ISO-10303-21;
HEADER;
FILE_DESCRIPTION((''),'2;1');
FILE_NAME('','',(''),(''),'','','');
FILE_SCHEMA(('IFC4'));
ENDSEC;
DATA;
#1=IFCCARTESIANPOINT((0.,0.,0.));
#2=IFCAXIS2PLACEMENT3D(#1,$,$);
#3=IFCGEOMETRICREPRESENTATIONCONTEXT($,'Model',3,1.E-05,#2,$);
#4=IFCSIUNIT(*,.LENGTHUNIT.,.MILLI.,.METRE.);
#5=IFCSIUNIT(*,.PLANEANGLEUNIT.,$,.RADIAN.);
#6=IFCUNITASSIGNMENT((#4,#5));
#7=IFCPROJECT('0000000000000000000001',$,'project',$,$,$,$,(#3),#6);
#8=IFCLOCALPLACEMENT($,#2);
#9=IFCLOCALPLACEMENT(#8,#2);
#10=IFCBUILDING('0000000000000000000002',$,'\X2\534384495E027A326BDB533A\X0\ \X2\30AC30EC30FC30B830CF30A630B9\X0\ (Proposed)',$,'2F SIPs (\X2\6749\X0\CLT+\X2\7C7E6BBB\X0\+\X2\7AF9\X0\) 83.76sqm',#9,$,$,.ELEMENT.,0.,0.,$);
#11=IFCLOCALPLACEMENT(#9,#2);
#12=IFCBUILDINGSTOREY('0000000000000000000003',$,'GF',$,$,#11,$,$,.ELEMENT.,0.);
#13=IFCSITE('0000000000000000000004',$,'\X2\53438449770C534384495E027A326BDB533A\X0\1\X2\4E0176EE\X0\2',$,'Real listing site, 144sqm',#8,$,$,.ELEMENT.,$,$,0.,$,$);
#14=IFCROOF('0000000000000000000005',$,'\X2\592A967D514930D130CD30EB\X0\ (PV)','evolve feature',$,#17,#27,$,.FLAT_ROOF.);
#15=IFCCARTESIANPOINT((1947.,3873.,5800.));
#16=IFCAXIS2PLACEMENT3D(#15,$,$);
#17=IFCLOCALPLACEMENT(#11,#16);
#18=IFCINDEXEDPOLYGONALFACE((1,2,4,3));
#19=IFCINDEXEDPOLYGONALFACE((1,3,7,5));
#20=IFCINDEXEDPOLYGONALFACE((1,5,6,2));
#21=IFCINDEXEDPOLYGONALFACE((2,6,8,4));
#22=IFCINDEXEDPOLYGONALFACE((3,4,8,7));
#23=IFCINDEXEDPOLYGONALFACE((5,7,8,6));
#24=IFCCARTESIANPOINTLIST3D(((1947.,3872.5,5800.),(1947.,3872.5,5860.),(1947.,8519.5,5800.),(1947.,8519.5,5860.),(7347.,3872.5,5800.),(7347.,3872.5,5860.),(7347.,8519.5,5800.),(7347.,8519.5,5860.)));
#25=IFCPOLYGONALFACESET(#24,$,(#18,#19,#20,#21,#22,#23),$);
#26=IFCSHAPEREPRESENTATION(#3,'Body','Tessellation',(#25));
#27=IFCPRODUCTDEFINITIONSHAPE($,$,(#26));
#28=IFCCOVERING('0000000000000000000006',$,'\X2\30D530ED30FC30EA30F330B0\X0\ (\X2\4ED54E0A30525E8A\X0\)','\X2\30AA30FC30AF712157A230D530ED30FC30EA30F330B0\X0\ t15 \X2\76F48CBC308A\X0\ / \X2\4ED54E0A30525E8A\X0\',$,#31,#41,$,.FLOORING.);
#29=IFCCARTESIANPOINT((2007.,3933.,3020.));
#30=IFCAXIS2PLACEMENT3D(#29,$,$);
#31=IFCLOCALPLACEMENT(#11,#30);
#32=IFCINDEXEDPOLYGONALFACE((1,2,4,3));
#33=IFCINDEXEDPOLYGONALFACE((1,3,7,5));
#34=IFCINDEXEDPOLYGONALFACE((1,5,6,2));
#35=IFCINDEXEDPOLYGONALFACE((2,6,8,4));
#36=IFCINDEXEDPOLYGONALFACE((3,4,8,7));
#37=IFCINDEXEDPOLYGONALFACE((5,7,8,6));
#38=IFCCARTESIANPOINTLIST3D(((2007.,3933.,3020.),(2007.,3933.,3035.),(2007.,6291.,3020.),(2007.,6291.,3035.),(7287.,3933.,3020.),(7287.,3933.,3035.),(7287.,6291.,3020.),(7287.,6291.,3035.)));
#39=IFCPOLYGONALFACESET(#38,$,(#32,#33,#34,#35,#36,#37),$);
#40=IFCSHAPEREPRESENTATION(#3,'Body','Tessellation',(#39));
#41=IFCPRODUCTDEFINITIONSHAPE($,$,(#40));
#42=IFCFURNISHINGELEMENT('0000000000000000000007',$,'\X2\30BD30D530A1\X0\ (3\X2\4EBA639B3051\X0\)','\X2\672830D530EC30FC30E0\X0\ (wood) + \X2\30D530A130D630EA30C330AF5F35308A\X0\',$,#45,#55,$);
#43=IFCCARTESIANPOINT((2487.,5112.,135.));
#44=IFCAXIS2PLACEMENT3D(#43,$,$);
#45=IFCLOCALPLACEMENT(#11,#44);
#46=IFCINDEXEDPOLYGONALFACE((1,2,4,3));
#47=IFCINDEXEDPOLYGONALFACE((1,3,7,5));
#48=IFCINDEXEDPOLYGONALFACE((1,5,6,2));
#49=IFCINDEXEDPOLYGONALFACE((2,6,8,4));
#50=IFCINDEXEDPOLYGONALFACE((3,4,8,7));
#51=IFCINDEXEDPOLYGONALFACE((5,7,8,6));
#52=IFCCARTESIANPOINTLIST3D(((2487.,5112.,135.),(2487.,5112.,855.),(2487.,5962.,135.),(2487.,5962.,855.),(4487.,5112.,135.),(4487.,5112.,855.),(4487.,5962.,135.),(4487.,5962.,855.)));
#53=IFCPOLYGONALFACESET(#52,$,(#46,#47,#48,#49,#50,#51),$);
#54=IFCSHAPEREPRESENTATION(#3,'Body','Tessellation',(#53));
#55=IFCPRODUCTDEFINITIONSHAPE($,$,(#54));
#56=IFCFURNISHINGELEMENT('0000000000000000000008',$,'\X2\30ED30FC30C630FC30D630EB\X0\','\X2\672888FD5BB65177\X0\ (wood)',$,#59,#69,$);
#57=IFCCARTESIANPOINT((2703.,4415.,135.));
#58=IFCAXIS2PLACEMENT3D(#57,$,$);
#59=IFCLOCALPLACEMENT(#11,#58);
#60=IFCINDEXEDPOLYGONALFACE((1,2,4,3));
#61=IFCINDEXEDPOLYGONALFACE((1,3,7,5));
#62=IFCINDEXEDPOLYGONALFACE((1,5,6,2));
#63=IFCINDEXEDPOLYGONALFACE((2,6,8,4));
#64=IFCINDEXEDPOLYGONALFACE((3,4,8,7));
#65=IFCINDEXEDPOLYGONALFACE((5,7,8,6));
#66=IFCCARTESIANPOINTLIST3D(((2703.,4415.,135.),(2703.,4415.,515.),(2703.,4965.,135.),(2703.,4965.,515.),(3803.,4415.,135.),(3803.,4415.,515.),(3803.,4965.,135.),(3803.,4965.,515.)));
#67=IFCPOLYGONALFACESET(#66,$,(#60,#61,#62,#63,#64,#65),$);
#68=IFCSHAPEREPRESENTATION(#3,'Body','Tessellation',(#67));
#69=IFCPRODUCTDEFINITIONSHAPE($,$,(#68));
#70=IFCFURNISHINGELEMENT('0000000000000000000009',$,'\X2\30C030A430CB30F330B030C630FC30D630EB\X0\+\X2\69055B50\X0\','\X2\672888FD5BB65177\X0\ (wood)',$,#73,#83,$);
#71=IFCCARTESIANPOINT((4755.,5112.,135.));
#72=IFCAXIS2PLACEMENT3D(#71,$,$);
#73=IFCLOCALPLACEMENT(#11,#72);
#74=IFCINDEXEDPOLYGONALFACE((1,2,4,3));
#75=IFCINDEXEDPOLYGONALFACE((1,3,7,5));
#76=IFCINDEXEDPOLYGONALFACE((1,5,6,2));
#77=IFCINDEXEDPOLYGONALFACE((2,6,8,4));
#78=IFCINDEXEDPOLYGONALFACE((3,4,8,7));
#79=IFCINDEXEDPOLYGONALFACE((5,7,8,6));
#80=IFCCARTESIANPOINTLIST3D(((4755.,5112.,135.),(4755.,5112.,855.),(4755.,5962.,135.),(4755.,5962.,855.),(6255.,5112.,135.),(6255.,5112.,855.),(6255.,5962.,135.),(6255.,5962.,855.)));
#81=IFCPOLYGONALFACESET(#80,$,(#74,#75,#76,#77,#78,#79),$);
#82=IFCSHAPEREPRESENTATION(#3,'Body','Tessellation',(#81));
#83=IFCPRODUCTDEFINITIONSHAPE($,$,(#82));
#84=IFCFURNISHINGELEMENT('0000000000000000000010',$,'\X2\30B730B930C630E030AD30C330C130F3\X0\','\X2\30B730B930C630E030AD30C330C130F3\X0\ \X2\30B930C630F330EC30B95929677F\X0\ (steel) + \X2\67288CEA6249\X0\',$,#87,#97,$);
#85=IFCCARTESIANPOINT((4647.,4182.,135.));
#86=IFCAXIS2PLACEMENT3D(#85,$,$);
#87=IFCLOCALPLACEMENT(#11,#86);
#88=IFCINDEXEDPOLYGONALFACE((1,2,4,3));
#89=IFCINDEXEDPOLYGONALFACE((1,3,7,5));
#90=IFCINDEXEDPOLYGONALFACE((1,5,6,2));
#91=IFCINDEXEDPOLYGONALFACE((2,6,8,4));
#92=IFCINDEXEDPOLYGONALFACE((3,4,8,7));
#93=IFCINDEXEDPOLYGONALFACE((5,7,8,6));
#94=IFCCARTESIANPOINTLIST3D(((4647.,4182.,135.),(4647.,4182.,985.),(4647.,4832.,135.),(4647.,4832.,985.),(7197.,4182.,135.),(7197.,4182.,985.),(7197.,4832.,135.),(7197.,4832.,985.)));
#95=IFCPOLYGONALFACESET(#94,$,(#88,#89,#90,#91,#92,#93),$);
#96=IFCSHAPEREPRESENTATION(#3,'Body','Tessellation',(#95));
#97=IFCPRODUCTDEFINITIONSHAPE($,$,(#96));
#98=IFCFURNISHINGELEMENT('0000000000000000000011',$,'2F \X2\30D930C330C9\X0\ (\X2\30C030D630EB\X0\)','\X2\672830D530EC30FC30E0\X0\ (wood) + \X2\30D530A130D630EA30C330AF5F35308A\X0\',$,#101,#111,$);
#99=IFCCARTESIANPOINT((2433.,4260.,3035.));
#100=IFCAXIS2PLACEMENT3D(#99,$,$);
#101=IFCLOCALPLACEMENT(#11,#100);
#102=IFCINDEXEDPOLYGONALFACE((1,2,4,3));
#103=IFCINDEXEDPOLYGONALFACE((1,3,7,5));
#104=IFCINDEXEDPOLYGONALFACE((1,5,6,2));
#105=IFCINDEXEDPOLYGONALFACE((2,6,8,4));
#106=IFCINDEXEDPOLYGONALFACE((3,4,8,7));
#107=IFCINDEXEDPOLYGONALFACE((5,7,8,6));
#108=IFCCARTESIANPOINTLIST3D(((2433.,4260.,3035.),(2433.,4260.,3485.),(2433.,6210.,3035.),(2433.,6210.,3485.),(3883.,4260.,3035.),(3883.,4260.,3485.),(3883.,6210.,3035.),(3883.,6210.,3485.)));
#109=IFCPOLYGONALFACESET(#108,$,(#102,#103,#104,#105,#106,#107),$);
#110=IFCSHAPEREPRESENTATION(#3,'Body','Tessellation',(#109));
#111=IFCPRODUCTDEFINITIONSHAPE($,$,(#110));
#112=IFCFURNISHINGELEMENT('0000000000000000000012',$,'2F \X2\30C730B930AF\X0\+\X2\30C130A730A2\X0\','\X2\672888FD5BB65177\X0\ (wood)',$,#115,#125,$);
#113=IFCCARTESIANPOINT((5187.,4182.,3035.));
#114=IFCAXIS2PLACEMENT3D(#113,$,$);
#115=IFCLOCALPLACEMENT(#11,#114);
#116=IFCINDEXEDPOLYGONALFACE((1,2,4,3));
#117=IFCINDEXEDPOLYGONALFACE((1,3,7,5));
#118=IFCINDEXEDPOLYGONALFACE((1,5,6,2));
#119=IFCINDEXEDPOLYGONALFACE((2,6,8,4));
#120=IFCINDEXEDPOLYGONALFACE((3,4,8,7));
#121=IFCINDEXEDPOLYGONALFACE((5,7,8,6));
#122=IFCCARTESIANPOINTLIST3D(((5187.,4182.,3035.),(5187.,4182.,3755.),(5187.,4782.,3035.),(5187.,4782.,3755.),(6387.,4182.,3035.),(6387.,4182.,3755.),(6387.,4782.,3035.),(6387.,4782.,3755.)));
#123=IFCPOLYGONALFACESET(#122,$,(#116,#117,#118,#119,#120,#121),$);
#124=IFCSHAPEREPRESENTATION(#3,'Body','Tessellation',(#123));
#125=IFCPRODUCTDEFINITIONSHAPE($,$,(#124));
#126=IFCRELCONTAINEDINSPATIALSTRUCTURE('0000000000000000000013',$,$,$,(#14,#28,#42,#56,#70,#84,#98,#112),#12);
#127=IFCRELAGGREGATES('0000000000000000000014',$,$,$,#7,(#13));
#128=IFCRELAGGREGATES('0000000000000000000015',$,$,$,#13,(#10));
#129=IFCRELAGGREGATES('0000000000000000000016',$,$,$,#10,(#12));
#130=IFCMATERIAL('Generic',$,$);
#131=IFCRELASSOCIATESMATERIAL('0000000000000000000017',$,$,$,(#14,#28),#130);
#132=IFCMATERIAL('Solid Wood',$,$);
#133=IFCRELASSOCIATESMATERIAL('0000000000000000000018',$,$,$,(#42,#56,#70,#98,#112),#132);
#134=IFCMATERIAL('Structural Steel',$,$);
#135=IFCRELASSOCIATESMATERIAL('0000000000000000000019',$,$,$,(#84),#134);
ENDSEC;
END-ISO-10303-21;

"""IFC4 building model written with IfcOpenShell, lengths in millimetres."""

from ifc_helpers import new_model, si_unit, frame, frame_2d, origin, place, context, project, spatial, rectangle, extrude, material, element, save


model = new_model("IFC4")

# Units and contexts
model_context = context("Model", 3, precision=1e-05, world=origin())
ifc_project = project(units=[si_unit("LENGTHUNIT", "METRE", prefix="MILLI"), si_unit("PLANEANGLEUNIT", "RADIAN")], contexts=[model_context])

# Site, building, storey
site_placement = place(None, origin())
site = spatial("IfcSite", under=ifc_project, at=site_placement, Name="千葉県千葉市稲毛区1丁目2", ObjectType="Real listing site, 144sqm", CompositionType="ELEMENT", RefElevation=0.0)
building_placement = place(site_placement, origin())
building = spatial("IfcBuilding", under=site, at=building_placement, Name="千葉市稲毛区 ガレージハウス (Proposed)", ObjectType="2F SIPs (杉CLT+籾殻+竹) 83.76sqm", CompositionType="ELEMENT", ElevationOfRefHeight=0.0, ElevationOfTerrain=0.0)
storey_placement = place(building_placement, origin())
storey = spatial("IfcBuildingStorey", under=building, at=storey_placement, Name="GF", CompositionType="ELEMENT", Elevation=0.0)

# Shared definitions
ifc_material_1 = material(Name="Solid Wood")

# Shared definitions
ifc_material_2 = material(Name="Generic")

# Roof
ifc_material_3 = material(Name="Structural Steel")
roof_1_placement = place(storey_placement, frame((1947.0, 3873.0, 5800.0)))
element("IfcRoof", 1, at=roof_1_placement, inside=storey, material=ifc_material_2, Name="太陽光パネル (PV)", Description="evolve feature", PredefinedType="FLAT_ROOF", context=model_context, shape_type="SweptSolid", body=[
    extrude(rectangle(XDim=5400.0, YDim=4647.0, at=frame_2d((2700.0, 2323.0))), frame((1947.0, 3873.0, 5800.0)), (0.0, 0.0, 1.0), 60.0),
])

# Covering
covering_placement = place(storey_placement, frame((2007.0, 3933.0, 3020.0)))
element("IfcCovering", 2, at=covering_placement, inside=storey, material=ifc_material_2, Name="フローリング (仕上げ床)", Description="オーク無垢フローリング t15 直貼り / 仕上げ床", PredefinedType="FLOORING", context=model_context, shape_type="SweptSolid", body=[
    extrude(rectangle(XDim=5280.0, YDim=2358.0, at=frame_2d((2640.0, 1179.0))), frame((2007.0, 3933.0, 3020.0)), (0.0, 0.0, 1.0), 15.0),
])

# Furnishing elements
furnishing_1_placement = place(storey_placement, frame((2487.0, 5112.0, 135.0)))
element("IfcFurnishingElement", 3, at=furnishing_1_placement, inside=storey, material=ifc_material_1, Name="ソファ (3人掛け)", Description="木フレーム (wood) + ファブリック張り", context=model_context, shape_type="SweptSolid", body=[
    extrude(rectangle(XDim=2000.0, YDim=850.0, at=frame_2d((1000.0, 425.0))), frame((2487.0, 5112.0, 135.0)), (0.0, 0.0, 1.0), 720.0),
])
furnishing_2_placement = place(storey_placement, frame((2703.0, 4415.0, 135.0)))
element("IfcFurnishingElement", 4, at=furnishing_2_placement, inside=storey, material=ifc_material_1, Name="ローテーブル", Description="木製家具 (wood)", context=model_context, shape_type="SweptSolid", body=[
    extrude(rectangle(XDim=1100.0, YDim=550.0, at=frame_2d((550.0, 275.0))), frame((2703.0, 4415.0, 135.0)), (0.0, 0.0, 1.0), 380.0),
])
furnishing_3_placement = place(storey_placement, frame((4755.0, 5112.0, 135.0)))
element("IfcFurnishingElement", 5, at=furnishing_3_placement, inside=storey, material=ifc_material_1, Name="ダイニングテーブル+椅子", Description="木製家具 (wood)", context=model_context, shape_type="SweptSolid", body=[
    extrude(rectangle(XDim=1500.0, YDim=850.0, at=frame_2d((750.0, 425.0))), frame((4755.0, 5112.0, 135.0)), (0.0, 0.0, 1.0), 720.0),
])
furnishing_4_placement = place(storey_placement, frame((4647.0, 4182.0, 135.0)))
element("IfcFurnishingElement", 6, at=furnishing_4_placement, inside=storey, material=ifc_material_3, Name="システムキッチン", Description="システムキッチン ステンレス天板 (steel) + 木質扉", context=model_context, shape_type="SweptSolid", body=[
    extrude(rectangle(XDim=2550.0, YDim=650.0, at=frame_2d((1275.0, 325.0))), frame((4647.0, 4182.0, 135.0)), (0.0, 0.0, 1.0), 850.0),
])
furnishing_5_placement = place(storey_placement, frame((2433.0, 4260.0, 3035.0)))
element("IfcFurnishingElement", 7, at=furnishing_5_placement, inside=storey, material=ifc_material_1, Name="2F ベッド (ダブル)", Description="木フレーム (wood) + ファブリック張り", context=model_context, shape_type="SweptSolid", body=[
    extrude(rectangle(XDim=1450.0, YDim=1950.0, at=frame_2d((725.0, 975.0))), frame((2433.0, 4260.0, 3035.0)), (0.0, 0.0, 1.0), 450.0),
])
furnishing_6_placement = place(storey_placement, frame((5187.0, 4182.0, 3035.0)))
element("IfcFurnishingElement", 8, at=furnishing_6_placement, inside=storey, material=ifc_material_1, Name="2F デスク+チェア", Description="木製家具 (wood)", context=model_context, shape_type="SweptSolid", body=[
    extrude(rectangle(XDim=1200.0, YDim=600.0, at=frame_2d((600.0, 300.0))), frame((5187.0, 4182.0, 3035.0)), (0.0, 0.0, 1.0), 720.0),
])

save(model, "model.ifc")
